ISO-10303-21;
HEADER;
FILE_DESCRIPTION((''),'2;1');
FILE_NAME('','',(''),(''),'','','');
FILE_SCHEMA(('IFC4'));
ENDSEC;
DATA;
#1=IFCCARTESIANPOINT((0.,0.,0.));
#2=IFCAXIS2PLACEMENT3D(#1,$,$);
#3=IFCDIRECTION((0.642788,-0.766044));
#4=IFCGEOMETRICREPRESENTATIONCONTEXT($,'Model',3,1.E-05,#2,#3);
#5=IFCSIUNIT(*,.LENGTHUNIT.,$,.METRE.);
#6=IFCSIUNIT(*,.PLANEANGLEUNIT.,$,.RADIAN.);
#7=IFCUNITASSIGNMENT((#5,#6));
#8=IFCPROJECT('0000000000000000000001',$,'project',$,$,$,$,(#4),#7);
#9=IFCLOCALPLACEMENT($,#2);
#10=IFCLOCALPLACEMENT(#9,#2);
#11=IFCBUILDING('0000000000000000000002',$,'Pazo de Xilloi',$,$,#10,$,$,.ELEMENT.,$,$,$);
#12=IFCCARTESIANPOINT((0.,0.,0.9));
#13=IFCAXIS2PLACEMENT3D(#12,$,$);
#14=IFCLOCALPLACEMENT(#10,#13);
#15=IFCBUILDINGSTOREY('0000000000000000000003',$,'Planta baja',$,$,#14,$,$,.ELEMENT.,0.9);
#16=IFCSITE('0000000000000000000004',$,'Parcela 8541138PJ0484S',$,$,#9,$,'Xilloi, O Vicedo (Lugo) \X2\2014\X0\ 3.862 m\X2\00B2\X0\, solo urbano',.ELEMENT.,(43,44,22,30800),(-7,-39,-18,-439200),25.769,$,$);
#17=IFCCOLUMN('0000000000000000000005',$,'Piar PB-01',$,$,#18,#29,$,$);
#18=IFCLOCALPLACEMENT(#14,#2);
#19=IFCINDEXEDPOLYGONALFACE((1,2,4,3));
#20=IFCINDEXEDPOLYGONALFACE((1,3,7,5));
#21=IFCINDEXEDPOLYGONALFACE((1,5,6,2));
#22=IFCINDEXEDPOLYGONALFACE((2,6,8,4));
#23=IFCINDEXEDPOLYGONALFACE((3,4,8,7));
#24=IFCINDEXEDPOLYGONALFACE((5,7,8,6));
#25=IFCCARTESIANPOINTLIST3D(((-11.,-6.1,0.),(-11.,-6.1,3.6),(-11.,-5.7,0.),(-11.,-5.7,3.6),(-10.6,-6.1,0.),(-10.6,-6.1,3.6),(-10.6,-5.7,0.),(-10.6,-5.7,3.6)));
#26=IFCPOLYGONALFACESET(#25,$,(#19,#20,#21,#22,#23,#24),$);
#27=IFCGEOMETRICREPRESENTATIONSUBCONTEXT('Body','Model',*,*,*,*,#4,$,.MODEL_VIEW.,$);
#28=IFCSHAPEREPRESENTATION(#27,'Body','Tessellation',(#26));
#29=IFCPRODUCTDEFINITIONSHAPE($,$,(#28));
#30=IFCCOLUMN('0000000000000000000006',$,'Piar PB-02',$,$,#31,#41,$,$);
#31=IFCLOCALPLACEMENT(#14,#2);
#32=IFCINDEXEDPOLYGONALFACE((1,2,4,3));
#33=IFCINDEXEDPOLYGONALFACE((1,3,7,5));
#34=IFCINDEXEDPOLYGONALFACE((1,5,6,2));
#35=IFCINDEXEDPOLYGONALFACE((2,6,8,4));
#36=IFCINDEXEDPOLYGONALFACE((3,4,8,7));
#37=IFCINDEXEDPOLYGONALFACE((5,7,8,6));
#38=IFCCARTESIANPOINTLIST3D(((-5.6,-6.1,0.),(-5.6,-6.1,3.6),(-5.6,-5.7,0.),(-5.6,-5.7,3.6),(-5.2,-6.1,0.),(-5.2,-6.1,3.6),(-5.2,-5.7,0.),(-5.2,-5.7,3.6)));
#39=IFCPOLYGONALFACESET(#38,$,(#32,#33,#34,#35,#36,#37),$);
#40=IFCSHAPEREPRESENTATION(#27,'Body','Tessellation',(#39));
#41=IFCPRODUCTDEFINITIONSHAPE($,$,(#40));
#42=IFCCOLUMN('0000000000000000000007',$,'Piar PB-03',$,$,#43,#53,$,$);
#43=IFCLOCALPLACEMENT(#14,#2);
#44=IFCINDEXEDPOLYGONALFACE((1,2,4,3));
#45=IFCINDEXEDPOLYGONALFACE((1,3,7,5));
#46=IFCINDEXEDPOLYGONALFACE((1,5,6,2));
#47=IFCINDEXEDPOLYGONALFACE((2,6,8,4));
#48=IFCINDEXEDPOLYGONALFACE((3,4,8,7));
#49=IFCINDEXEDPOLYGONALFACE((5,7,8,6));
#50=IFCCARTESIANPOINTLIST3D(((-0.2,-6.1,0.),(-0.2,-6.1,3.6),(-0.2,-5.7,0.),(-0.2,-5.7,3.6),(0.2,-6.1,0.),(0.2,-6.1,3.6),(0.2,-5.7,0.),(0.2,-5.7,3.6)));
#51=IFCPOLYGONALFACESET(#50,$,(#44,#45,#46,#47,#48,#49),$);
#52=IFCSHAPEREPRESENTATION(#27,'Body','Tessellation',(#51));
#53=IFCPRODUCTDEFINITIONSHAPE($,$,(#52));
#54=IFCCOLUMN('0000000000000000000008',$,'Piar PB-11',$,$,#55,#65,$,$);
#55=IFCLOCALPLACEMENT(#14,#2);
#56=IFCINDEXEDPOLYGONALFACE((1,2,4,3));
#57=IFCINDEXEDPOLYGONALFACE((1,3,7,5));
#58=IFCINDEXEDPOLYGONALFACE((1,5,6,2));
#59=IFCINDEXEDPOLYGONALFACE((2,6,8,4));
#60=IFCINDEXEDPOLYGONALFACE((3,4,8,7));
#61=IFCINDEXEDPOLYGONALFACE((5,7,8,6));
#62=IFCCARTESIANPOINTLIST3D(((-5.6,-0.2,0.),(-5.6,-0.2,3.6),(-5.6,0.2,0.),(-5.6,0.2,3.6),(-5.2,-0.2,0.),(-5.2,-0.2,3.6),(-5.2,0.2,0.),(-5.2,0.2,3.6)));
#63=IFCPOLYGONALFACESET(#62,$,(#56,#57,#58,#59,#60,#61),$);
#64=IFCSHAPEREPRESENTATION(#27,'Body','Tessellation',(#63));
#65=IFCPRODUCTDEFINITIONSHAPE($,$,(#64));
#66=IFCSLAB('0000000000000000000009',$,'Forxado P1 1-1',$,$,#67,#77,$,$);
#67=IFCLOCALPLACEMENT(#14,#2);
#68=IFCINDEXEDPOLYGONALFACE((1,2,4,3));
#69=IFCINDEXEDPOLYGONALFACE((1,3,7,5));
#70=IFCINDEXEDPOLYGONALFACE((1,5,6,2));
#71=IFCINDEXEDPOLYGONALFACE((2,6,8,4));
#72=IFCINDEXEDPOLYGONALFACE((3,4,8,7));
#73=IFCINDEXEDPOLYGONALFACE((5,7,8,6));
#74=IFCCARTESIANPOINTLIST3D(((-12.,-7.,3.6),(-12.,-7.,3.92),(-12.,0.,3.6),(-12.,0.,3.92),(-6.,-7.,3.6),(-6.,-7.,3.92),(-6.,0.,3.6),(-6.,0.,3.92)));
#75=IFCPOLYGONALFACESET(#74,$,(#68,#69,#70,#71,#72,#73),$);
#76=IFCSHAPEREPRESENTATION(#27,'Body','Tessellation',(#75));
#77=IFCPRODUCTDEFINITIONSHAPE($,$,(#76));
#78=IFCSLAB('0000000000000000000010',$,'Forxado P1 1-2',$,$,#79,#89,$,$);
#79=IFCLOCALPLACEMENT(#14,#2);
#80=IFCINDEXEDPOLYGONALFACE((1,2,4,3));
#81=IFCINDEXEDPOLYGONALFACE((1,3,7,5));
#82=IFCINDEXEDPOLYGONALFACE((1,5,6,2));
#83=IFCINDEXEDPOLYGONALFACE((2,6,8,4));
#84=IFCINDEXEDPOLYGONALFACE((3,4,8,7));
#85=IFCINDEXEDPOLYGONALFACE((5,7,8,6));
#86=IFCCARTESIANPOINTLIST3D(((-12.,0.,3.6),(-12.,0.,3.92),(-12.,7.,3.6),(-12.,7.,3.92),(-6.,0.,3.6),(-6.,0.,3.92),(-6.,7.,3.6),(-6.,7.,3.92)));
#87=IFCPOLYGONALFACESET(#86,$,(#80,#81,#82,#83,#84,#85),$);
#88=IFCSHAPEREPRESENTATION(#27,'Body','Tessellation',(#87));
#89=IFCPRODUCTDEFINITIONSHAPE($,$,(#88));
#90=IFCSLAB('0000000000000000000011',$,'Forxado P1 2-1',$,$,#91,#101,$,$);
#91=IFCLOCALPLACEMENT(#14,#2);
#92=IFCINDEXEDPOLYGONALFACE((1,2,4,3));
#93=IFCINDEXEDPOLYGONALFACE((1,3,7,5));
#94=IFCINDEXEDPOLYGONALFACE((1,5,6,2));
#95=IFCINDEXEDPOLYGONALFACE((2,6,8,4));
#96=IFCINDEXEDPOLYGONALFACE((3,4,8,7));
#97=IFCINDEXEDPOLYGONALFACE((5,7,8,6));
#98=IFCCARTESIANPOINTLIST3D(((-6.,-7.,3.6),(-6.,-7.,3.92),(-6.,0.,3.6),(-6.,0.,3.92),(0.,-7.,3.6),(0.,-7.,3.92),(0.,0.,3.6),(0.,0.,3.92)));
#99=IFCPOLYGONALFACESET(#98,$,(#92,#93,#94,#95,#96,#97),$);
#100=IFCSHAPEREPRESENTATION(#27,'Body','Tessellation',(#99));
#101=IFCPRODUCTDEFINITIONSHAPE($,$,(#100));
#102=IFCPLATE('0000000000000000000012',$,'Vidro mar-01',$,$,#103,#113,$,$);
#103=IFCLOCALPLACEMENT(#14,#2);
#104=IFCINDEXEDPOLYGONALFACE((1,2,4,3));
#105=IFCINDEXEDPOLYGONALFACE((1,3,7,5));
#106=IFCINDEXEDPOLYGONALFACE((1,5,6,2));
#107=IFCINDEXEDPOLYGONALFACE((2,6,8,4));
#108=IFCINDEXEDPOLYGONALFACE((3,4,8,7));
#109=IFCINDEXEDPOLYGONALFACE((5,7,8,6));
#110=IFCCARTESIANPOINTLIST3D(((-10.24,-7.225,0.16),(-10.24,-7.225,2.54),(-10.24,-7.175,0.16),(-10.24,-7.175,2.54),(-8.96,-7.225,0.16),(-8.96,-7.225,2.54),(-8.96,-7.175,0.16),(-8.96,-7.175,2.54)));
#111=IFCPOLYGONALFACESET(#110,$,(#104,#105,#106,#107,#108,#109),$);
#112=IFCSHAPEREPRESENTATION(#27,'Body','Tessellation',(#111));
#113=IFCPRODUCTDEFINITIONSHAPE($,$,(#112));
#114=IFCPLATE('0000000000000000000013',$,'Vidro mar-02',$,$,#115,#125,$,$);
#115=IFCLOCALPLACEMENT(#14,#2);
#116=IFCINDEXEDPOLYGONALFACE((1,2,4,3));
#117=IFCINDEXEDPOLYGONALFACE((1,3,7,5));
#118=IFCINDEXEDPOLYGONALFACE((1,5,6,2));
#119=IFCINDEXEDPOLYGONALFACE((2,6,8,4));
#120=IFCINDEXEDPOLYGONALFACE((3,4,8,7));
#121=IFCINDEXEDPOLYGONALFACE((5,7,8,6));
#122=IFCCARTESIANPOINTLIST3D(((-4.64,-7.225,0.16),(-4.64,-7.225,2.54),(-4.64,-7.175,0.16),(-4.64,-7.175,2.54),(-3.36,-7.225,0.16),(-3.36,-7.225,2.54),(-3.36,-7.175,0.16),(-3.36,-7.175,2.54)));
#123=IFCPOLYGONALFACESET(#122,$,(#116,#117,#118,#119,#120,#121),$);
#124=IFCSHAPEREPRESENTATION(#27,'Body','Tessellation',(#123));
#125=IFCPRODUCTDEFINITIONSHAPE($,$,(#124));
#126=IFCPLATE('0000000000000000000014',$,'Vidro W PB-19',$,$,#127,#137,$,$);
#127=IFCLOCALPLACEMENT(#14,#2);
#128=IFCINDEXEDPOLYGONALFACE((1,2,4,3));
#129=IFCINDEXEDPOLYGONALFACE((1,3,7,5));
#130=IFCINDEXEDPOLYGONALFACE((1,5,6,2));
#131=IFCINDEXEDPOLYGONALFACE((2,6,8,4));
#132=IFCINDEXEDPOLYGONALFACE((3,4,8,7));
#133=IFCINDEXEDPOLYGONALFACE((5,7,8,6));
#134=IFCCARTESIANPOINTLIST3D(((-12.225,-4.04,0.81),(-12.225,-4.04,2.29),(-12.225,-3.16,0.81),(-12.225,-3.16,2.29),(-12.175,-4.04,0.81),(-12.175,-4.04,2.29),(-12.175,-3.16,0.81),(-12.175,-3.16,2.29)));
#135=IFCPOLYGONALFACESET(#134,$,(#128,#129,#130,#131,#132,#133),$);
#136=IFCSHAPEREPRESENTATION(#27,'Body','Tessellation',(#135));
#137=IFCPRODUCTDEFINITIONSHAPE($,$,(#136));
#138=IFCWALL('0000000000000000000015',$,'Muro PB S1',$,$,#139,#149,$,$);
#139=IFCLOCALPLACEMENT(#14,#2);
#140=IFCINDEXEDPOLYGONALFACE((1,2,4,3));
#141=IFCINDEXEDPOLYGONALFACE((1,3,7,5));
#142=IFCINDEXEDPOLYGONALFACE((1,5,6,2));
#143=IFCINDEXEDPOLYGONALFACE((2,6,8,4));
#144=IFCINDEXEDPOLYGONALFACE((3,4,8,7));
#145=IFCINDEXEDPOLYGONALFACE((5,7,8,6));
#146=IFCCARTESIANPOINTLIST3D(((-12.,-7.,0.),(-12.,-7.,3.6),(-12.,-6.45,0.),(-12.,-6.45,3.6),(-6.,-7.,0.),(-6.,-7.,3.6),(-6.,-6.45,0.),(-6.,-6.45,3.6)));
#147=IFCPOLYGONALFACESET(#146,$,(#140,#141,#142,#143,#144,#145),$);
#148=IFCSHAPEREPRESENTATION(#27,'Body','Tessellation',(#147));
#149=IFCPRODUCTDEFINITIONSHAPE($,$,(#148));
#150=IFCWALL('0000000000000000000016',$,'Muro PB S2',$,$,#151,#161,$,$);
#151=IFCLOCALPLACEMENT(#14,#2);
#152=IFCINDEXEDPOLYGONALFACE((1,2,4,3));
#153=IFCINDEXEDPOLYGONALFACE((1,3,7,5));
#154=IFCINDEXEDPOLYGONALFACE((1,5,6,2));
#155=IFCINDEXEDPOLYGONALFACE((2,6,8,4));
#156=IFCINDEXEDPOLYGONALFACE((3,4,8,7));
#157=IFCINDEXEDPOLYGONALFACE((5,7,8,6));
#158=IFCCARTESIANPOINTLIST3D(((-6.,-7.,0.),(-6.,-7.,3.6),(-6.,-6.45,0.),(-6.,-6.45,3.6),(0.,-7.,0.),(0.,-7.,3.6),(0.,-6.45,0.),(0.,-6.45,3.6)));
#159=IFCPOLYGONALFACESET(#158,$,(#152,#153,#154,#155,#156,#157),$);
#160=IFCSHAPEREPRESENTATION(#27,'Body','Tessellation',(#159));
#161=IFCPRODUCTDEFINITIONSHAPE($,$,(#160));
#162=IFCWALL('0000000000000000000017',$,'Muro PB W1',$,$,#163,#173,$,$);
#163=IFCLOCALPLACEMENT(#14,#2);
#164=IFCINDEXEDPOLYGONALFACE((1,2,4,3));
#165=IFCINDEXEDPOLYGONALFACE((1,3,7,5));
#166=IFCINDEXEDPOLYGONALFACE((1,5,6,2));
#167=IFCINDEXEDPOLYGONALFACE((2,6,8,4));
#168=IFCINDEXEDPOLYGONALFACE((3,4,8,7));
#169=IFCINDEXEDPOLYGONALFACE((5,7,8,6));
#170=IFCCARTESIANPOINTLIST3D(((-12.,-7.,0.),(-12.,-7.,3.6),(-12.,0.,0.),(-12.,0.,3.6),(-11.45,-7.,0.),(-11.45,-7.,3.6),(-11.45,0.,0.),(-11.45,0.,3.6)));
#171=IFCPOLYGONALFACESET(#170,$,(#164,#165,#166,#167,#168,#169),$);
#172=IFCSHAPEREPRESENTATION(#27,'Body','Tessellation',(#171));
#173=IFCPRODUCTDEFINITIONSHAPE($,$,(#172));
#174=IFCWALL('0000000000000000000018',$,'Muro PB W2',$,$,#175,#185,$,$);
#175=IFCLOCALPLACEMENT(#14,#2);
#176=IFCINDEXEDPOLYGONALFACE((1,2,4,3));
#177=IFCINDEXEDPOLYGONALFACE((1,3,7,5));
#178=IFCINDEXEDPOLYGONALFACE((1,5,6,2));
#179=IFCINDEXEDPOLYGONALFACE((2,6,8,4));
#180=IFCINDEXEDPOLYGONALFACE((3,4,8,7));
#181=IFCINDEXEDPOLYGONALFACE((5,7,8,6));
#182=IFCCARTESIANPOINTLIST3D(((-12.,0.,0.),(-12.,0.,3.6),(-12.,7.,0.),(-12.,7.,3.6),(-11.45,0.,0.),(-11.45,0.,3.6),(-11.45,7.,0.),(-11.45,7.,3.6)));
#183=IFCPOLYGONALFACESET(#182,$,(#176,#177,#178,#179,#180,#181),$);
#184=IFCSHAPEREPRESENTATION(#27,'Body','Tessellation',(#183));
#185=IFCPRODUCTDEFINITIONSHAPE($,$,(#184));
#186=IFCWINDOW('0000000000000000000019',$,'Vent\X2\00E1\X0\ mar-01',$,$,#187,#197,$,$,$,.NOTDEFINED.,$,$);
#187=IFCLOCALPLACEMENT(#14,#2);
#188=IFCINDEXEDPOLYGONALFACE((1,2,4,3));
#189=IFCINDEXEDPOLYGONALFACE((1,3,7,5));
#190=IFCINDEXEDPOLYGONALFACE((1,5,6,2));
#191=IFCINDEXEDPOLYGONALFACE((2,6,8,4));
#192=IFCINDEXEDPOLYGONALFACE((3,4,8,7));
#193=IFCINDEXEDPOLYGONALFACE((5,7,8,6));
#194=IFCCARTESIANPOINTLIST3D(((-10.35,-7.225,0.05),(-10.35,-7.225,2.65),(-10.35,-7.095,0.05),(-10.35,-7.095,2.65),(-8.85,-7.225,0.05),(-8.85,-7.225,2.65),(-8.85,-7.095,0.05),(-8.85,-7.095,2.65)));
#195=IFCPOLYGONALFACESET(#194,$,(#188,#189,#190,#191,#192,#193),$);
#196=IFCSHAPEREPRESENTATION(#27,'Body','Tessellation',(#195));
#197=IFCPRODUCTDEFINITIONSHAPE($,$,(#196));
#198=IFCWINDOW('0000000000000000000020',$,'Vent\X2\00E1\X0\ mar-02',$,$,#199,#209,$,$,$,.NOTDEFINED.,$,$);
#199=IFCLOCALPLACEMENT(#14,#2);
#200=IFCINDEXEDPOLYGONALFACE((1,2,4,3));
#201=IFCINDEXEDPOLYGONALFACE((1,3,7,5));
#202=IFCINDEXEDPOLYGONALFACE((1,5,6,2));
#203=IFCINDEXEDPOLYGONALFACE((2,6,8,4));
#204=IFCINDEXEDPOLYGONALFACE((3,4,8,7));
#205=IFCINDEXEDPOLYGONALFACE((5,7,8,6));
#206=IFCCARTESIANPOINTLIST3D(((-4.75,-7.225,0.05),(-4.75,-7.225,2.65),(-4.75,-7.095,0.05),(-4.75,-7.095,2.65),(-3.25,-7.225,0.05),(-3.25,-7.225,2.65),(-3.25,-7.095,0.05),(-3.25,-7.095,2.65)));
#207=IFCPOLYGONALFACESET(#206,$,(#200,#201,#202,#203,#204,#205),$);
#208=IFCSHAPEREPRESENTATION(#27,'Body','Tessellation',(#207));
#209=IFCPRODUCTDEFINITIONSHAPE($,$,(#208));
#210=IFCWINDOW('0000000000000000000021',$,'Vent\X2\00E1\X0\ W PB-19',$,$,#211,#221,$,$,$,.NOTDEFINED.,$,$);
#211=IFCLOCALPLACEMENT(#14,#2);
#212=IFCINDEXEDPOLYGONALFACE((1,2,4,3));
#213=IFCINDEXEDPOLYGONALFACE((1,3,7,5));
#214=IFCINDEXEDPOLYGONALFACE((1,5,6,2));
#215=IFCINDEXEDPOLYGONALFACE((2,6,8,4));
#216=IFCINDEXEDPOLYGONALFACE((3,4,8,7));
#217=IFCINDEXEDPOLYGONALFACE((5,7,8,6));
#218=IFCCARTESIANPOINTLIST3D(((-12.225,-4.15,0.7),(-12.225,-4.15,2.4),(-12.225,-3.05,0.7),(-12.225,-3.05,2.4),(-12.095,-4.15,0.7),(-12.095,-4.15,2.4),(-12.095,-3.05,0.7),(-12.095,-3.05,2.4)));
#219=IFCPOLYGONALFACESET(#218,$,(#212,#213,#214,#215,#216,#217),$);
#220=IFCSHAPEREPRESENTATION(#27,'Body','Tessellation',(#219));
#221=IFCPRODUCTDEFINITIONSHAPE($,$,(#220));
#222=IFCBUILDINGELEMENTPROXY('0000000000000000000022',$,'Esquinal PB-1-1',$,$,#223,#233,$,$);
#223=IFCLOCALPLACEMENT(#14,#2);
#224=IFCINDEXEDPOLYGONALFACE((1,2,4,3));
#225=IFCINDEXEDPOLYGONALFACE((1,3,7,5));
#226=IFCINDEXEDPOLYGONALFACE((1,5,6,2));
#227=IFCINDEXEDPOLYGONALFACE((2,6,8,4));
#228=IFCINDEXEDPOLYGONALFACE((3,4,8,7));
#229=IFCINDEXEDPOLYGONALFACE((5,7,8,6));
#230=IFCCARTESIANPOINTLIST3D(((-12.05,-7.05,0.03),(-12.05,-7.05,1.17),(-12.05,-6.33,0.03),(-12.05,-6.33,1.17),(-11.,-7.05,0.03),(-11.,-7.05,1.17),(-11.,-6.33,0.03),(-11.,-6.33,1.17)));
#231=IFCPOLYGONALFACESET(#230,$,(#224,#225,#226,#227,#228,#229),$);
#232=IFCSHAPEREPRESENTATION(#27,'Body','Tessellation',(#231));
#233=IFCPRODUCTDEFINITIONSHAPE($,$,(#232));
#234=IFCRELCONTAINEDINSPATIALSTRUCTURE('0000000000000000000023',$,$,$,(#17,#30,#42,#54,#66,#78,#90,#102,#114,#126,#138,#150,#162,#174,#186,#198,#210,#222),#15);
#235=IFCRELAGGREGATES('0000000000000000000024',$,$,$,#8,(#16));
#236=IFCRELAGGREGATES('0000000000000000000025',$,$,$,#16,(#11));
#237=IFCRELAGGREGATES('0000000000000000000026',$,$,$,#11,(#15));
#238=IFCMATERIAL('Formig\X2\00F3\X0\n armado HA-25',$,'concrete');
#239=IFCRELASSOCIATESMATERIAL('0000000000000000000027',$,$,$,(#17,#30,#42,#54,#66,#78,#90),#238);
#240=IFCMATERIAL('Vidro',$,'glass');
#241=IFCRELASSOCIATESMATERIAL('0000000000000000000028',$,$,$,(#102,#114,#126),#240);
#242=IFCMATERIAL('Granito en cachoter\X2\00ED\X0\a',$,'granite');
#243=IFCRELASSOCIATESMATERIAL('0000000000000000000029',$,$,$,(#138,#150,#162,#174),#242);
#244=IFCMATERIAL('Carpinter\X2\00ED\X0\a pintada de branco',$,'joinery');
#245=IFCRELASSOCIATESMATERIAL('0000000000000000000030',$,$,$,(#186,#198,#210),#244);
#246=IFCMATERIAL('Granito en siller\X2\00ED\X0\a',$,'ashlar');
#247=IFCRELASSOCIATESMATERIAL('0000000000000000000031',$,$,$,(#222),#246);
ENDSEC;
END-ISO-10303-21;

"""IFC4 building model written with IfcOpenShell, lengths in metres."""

from ifc_helpers import new_model, si_unit, direction, frame, origin, origin_2d, place, context, subcontext, project, spatial, rectangle, extrude, material, element, save


model = new_model("IFC4")

# Units and contexts
model_context = context("Model", 3, precision=1e-05, world=origin(), true_north=direction((0.642788, -0.766044)))
body_context = subcontext(model_context, "Body", "Model", "MODEL_VIEW")
ifc_project = project(units=[si_unit("LENGTHUNIT", "METRE"), si_unit("PLANEANGLEUNIT", "RADIAN")], contexts=[model_context])

# Site, building, storey
site_placement = place(None, origin())
site = spatial("IfcSite", under=ifc_project, at=site_placement, Name="Parcela 8541138PJ0484S", LongName="Xilloi, O Vicedo (Lugo) — 3.862 m², solo urbano", CompositionType="ELEMENT", RefLatitude=(43, 44, 22, 30800), RefLongitude=(-7, -39, -18, -439200), RefElevation=25.769)
building_placement = place(site_placement, origin())
building = spatial("IfcBuilding", under=site, at=building_placement, Name="Pazo de Xilloi", CompositionType="ELEMENT")
storey_placement = place(building_placement, frame((0.0, 0.0, 0.9)))
storey = spatial("IfcBuildingStorey", under=building, at=storey_placement, Name="Planta baja", CompositionType="ELEMENT", Elevation=0.9)

# Columns
ifc_material_1 = material(Name="Formigón armado HA-25", Category="concrete")
for number, where, name in (
    (1, (-10.8, -5.9, 1.8), "Piar PB-01"),
    (2, (-5.4, -5.9, 1.8), "Piar PB-02"),
    (3, (0.0, -5.9, 1.8), "Piar PB-03"),
    (4, (-5.4, 0.0, 1.8), "Piar PB-11"),
):
    element("IfcColumn", number, at=place(storey_placement, frame(where)), inside=storey, material=ifc_material_1, Name=name, context=body_context, shape_type="SweptSolid", body=[
        extrude(rectangle(XDim=0.4, YDim=0.4, at=origin_2d()), frame((0.0, 0.0, -1.8)), (0.0, 0.0, 1.0), 3.6),
    ])

# Slabs
for number, where, name in (
    (5, (-9.0, -3.5, 3.76), "Forxado P1 1-1"),
    (6, (-9.0, 3.5, 3.76), "Forxado P1 1-2"),
    (7, (-3.0, -3.5, 3.76), "Forxado P1 2-1"),
):
    element("IfcSlab", number, at=place(storey_placement, frame(where)), inside=storey, material=ifc_material_1, Name=name, context=body_context, shape_type="SweptSolid", body=[
        extrude(rectangle(XDim=6.0, YDim=7.0, at=origin_2d()), frame((0.0, 0.0, -0.16)), (0.0, 0.0, 1.0), 0.32),
    ])

# Plates
ifc_material_2 = material(Name="Vidro", Category="glass")
for number, where, name in (
    (8, (-9.6, -7.2, 1.35), "Vidro mar-01"),
    (9, (-4.0, -7.2, 1.35), "Vidro mar-02"),
):
    element("IfcPlate", number, at=place(storey_placement, frame(where)), inside=storey, material=ifc_material_2, Name=name, context=body_context, shape_type="SweptSolid", body=[
        extrude(rectangle(XDim=1.28, YDim=0.05, at=origin_2d()), frame((0.0, 0.0, -1.19)), (0.0, 0.0, 1.0), 2.38),
    ])
plate_placement = place(storey_placement, frame((-12.2, -3.6, 1.55)))
element("IfcPlate", 10, at=plate_placement, inside=storey, material=ifc_material_2, Name="Vidro W PB-19", context=body_context, shape_type="SweptSolid", body=[
    extrude(rectangle(XDim=0.05, YDim=0.88, at=origin_2d()), frame((0.0, 0.0, -0.74)), (0.0, 0.0, 1.0), 1.48),
])

# Walls
ifc_material_3 = material(Name="Granito en cachotería", Category="granite")
for number, where, name in (
    (11, (-9.0, -6.725, 1.8), "Muro PB S1"),
    (12, (-3.0, -6.725, 1.8), "Muro PB S2"),
):
    element("IfcWall", number, at=place(storey_placement, frame(where)), inside=storey, material=ifc_material_3, Name=name, context=body_context, shape_type="SweptSolid", body=[
        extrude(rectangle(XDim=6.0, YDim=0.55, at=origin_2d()), frame((0.0, 0.0, -1.8)), (0.0, 0.0, 1.0), 3.6),
    ])
for number, where, name in (
    (13, (-11.725, -3.5, 1.8), "Muro PB W1"),
    (14, (-11.725, 3.5, 1.8), "Muro PB W2"),
):
    element("IfcWall", number, at=place(storey_placement, frame(where)), inside=storey, material=ifc_material_3, Name=name, context=body_context, shape_type="SweptSolid", body=[
        extrude(rectangle(XDim=0.55, YDim=7.0, at=origin_2d()), frame((0.0, 0.0, -1.8)), (0.0, 0.0, 1.0), 3.6),
    ])

# Windows
ifc_material_4 = material(Name="Carpintería pintada de branco", Category="joinery")
for number, where, name in (
    (15, (-9.6, -7.16, 1.35), "Ventá mar-01"),
    (16, (-4.0, -7.16, 1.35), "Ventá mar-02"),
):
    element("IfcWindow", number, at=place(storey_placement, frame(where)), inside=storey, material=ifc_material_4, Name=name, PredefinedType="NOTDEFINED", context=body_context, shape_type="SweptSolid", body=[
        extrude(rectangle(XDim=1.5, YDim=0.13, at=origin_2d()), frame((0.0, 0.0, -1.3)), (0.0, 0.0, 1.0), 2.6),
    ])
window_placement = place(storey_placement, frame((-12.16, -3.6, 1.55)))
element("IfcWindow", 17, at=window_placement, inside=storey, material=ifc_material_4, Name="Ventá W PB-19", PredefinedType="NOTDEFINED", context=body_context, shape_type="SweptSolid", body=[
    extrude(rectangle(XDim=0.13, YDim=1.1, at=origin_2d()), frame((0.0, 0.0, -0.85)), (0.0, 0.0, 1.0), 1.7),
])

# Building element proxy
ifc_material_5 = material(Name="Granito en sillería", Category="ashlar")
proxy_1_placement = place(storey_placement, frame((-11.525, -6.69, 0.6)))
element("IfcBuildingElementProxy", 18, at=proxy_1_placement, inside=storey, material=ifc_material_5, Name="Esquinal PB-1-1", context=body_context, shape_type="SweptSolid", body=[
    extrude(rectangle(XDim=1.05, YDim=0.72, at=origin_2d()), frame((0.0, 0.0, -0.57)), (0.0, 0.0, 1.0), 1.14),
])

save(model, "model.ifc")
